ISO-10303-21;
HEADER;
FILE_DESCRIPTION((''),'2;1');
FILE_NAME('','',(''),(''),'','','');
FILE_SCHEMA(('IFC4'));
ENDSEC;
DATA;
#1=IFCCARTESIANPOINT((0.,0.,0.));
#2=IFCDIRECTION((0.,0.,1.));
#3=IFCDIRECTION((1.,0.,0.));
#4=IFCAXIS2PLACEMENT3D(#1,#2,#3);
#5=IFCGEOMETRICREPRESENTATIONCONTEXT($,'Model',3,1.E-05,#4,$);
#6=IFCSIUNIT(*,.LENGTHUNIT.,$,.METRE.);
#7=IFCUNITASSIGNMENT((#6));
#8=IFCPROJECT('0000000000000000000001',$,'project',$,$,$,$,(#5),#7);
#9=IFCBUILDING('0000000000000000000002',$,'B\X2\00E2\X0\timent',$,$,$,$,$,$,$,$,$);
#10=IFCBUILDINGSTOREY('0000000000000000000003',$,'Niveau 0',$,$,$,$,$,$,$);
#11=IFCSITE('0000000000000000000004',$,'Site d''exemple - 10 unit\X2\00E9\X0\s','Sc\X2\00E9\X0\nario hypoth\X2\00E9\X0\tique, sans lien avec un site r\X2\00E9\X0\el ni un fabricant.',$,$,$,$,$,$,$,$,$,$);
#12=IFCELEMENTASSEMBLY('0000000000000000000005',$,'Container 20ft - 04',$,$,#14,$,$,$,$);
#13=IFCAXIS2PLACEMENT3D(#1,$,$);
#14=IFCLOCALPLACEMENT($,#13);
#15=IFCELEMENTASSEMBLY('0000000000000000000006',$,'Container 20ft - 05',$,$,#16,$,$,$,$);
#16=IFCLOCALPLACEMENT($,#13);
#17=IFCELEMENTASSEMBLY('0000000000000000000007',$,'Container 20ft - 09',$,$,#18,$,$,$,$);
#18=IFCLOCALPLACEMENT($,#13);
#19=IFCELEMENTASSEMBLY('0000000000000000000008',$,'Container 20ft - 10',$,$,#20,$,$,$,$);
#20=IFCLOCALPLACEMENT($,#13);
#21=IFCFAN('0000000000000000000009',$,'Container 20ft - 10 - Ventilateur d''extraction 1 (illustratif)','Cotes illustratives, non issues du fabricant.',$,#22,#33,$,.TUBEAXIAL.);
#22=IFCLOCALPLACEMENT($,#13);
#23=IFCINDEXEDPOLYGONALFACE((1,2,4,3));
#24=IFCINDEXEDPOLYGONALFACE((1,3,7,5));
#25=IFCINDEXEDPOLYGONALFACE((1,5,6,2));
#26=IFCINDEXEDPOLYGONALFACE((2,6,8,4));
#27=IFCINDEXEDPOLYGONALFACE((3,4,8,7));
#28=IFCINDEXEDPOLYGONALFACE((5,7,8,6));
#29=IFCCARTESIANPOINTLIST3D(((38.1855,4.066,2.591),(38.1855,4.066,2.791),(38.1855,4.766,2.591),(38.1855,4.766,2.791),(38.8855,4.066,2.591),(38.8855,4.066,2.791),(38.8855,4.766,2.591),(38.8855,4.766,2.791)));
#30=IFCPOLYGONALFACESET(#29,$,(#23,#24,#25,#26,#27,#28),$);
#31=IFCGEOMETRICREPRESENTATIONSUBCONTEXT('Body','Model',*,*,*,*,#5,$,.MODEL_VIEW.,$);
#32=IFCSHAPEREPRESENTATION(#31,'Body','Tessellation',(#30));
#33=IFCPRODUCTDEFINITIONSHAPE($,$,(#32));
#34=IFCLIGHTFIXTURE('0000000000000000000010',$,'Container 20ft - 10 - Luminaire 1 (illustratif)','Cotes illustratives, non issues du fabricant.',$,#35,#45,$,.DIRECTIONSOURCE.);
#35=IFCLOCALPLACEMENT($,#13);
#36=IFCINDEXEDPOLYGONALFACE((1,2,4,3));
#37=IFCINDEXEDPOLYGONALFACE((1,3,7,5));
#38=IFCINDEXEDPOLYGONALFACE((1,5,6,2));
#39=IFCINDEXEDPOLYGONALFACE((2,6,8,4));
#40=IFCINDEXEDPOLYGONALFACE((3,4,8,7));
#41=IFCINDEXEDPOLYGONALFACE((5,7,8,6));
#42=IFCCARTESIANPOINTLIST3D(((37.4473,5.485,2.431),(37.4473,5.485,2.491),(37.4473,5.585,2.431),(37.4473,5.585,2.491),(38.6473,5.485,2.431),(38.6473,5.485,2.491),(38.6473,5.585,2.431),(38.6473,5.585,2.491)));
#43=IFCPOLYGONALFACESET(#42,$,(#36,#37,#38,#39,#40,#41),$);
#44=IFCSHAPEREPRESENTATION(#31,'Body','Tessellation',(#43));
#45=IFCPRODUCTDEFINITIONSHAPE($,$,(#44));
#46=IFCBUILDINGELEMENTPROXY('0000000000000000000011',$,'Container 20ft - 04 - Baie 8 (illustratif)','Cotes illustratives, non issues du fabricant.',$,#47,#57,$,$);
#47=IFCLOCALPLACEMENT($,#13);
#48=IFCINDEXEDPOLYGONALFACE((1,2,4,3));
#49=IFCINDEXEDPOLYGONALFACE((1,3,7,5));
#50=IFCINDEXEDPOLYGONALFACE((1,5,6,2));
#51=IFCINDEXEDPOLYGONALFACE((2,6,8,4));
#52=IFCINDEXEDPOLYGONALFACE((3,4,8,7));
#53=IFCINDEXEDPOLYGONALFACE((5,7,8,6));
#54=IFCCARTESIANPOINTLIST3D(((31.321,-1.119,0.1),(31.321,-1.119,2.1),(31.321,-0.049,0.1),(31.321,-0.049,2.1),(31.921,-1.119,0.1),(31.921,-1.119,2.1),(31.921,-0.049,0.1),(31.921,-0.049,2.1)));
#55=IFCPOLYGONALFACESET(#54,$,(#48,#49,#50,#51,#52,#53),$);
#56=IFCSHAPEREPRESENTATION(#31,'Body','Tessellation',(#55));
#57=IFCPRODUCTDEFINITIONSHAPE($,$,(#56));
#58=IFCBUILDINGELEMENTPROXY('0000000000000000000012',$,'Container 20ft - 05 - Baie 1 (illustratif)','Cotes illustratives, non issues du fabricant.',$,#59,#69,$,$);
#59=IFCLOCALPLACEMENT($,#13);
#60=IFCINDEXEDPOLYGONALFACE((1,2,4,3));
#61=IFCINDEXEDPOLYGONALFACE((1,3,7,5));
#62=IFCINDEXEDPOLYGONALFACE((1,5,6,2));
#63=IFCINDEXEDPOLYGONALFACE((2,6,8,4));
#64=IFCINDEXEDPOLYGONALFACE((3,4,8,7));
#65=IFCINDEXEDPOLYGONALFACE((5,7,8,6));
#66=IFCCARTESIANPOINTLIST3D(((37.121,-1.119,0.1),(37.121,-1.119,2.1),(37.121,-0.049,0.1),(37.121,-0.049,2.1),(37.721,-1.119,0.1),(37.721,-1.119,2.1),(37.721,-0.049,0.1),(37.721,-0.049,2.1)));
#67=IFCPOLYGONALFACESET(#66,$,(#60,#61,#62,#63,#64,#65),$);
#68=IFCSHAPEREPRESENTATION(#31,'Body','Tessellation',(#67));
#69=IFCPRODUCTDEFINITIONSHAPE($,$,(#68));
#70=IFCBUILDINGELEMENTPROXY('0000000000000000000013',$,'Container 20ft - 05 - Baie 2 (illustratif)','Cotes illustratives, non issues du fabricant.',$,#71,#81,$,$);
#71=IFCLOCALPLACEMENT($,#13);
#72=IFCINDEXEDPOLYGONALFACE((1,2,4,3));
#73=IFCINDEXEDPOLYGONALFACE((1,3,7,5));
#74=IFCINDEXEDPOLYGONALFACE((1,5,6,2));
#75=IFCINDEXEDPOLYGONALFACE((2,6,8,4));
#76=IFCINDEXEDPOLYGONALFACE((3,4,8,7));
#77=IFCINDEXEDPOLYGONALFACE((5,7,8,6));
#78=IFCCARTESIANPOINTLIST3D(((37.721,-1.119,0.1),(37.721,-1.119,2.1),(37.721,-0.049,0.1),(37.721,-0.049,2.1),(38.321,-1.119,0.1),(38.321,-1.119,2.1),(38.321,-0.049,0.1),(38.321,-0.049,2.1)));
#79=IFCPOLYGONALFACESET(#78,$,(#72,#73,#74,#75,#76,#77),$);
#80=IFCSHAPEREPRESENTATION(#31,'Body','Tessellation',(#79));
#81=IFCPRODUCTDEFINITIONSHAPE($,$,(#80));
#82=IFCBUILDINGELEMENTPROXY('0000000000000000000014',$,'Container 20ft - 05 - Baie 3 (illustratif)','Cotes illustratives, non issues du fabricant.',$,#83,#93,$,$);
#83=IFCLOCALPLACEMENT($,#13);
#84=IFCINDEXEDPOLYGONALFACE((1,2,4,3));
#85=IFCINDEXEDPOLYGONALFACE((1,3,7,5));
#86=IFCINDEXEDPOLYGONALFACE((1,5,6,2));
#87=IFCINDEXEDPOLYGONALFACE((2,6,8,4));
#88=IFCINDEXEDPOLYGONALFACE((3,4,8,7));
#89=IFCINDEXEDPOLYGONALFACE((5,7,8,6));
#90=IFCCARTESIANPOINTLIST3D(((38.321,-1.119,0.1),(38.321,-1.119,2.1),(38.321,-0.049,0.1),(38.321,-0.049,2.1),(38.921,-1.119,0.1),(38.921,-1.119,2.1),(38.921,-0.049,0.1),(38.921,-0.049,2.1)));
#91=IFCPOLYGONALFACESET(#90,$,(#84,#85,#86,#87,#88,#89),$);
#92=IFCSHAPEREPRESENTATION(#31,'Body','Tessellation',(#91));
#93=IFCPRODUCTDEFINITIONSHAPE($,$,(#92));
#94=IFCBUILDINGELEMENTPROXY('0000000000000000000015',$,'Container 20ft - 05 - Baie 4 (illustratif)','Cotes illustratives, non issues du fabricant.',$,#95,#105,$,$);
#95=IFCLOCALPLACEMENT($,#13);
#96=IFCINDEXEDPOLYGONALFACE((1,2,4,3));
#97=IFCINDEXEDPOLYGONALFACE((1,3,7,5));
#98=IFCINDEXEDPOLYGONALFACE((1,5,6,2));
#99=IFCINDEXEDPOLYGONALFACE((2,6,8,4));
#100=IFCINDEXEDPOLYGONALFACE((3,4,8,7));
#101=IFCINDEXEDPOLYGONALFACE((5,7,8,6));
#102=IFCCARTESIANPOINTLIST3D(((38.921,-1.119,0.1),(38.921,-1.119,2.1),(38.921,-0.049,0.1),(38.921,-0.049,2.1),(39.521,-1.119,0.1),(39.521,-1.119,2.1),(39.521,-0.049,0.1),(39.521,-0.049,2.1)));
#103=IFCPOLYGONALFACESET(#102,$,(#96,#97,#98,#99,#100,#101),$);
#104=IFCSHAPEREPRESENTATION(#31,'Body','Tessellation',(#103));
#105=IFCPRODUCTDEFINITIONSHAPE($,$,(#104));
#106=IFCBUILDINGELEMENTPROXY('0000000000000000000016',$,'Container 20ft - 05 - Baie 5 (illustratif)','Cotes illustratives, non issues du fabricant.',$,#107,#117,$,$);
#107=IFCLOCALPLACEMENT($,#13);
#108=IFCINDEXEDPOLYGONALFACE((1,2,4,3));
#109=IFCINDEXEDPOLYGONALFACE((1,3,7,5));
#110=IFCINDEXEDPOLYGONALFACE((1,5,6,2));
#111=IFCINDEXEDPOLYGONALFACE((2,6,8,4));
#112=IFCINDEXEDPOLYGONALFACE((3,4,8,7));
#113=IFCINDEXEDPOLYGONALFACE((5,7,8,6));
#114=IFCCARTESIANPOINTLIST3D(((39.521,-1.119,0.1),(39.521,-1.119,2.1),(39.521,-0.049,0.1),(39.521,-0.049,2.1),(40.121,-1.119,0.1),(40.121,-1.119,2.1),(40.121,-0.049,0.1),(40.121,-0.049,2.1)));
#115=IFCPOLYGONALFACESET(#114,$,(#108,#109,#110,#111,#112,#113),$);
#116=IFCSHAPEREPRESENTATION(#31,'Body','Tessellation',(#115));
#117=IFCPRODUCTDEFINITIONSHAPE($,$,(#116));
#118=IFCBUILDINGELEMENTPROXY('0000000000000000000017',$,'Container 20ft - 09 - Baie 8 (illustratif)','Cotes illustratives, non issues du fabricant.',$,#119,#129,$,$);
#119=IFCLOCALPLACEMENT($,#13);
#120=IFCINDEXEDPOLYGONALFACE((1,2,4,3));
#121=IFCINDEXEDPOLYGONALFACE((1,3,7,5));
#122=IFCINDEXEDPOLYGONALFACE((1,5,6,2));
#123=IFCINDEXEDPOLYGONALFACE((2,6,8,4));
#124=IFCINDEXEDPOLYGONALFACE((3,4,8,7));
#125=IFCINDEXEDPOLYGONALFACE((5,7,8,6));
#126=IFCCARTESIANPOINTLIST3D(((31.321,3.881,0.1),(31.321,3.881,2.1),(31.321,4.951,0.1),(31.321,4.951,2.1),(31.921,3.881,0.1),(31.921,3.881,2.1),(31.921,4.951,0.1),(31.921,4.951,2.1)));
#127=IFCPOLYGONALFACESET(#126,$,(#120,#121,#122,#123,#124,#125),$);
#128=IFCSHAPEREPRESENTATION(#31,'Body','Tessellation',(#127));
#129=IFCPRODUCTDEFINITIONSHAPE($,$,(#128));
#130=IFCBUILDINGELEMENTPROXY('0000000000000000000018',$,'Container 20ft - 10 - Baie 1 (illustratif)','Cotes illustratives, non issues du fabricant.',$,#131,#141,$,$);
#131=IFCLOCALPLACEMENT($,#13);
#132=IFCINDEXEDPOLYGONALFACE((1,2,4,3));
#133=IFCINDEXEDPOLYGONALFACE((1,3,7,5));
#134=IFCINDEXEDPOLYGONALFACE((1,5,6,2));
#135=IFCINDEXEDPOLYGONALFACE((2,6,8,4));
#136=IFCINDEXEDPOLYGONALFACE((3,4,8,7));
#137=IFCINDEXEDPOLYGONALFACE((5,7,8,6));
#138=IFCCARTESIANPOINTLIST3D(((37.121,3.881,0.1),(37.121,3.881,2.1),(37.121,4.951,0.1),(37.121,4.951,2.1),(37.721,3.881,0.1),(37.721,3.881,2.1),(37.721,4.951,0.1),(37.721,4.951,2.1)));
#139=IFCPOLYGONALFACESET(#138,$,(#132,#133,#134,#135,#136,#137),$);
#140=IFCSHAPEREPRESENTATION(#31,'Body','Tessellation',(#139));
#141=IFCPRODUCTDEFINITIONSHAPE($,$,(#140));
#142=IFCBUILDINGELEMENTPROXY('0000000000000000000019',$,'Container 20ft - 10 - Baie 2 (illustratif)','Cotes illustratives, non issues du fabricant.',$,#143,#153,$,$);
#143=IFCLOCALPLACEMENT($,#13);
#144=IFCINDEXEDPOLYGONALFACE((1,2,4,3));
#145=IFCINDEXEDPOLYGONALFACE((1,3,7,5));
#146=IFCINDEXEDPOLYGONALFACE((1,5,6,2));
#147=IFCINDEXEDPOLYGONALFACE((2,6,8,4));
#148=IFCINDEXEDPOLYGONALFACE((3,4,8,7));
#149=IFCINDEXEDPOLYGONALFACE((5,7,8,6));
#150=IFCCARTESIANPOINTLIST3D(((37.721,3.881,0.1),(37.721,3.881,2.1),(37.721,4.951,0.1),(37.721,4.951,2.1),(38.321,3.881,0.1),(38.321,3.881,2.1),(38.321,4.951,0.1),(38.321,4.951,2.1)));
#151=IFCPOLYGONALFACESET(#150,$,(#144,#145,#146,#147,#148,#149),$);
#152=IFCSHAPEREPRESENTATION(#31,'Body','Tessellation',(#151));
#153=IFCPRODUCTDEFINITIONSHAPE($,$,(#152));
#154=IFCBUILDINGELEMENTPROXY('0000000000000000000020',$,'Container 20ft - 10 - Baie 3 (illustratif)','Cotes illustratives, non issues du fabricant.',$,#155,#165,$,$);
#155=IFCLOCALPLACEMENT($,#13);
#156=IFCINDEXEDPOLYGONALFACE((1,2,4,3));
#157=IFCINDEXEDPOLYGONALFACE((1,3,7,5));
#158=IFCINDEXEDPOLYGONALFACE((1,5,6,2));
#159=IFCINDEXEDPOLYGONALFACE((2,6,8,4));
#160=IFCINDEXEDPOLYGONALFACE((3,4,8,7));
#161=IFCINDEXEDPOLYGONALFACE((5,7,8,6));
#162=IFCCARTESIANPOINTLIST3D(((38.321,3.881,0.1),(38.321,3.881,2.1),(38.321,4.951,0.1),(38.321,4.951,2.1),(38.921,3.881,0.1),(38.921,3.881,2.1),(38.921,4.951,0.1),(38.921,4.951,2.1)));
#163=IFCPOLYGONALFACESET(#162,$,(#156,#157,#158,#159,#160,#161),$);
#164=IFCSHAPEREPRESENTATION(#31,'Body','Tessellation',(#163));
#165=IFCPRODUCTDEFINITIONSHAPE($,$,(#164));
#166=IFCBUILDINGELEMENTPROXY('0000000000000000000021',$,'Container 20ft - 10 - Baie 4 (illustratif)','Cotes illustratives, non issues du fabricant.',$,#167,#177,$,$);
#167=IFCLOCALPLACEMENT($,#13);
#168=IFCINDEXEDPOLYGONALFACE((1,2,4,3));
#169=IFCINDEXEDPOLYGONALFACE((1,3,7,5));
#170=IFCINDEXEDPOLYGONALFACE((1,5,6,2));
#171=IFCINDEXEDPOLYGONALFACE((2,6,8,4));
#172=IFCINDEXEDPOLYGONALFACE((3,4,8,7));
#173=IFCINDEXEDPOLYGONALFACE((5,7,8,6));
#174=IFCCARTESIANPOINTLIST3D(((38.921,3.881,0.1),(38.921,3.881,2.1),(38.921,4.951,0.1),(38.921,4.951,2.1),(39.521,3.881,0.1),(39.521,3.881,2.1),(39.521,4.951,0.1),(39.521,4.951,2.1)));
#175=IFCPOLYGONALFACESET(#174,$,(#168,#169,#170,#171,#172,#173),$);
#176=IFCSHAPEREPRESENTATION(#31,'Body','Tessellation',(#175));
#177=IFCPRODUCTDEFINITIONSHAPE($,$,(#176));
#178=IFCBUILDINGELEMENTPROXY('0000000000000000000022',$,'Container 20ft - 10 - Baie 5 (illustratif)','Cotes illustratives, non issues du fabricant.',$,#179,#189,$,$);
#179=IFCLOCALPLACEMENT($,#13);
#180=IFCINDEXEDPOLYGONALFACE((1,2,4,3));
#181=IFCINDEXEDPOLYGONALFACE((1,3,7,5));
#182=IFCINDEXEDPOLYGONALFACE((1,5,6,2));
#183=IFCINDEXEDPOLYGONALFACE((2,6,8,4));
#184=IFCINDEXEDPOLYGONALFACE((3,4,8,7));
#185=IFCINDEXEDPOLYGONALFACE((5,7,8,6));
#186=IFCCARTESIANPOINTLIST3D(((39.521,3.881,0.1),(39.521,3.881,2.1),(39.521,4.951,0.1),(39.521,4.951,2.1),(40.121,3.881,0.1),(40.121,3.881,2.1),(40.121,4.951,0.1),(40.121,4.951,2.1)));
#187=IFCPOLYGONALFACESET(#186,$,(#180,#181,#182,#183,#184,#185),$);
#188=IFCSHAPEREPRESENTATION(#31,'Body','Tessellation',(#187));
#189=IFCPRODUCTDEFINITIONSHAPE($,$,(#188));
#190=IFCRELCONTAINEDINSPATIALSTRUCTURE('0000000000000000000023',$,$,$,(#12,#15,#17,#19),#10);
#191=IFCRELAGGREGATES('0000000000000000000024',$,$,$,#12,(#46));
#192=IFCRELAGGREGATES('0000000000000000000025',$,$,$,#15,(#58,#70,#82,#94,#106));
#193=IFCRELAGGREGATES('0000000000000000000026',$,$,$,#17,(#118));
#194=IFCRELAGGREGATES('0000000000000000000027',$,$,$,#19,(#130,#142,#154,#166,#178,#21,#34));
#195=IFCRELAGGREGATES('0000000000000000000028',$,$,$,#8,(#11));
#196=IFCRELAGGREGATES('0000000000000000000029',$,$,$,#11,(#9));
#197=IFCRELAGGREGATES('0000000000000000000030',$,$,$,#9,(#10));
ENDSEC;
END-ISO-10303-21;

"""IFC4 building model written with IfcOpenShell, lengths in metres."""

from ifc_helpers import new_model, si_unit, frame, origin_with_axes, place, context, subcontext, project, spatial, rectangle, extrude, element, aggregate, save


model = new_model("IFC4")

# Units and contexts
model_context = context("Model", 3, precision=1e-05, world=origin_with_axes())
body_context = subcontext(model_context, "Body", "Model", "MODEL_VIEW")
ifc_project = project(units=[si_unit("LENGTHUNIT", "METRE")], contexts=[model_context])

# Site, building, storey
site = spatial("IfcSite", under=ifc_project, Name="Site d'exemple - 10 unités", Description="Scénario hypothétique, sans lien avec un site réel ni un fabricant.")
building = spatial("IfcBuilding", under=site, Name="Bâtiment")
storey = spatial("IfcBuildingStorey", under=building, Name="Niveau 0")

# Element assembly
assembly_1 = element("IfcElementAssembly", 1, inside=storey, Name="Container 20ft - 04")

# Element assembly
assembly_2 = element("IfcElementAssembly", 2, inside=storey, Name="Container 20ft - 05")

# Element assembly
assembly_3 = element("IfcElementAssembly", 3, inside=storey, Name="Container 20ft - 09")

# Element assembly
assembly_4 = element("IfcElementAssembly", 4, inside=storey, Name="Container 20ft - 10")

# Fan
fan_1_placement = place(None, frame((38.5355, 4.416, 2.591), z_axis=(0.0, 0.0, 1.0), x_axis=(1.0, 0.0, 0.0)))
fan_1 = element("IfcFan", 5, at=fan_1_placement, Name="Container 20ft - 10 - Ventilateur d'extraction 1 (illustratif)", Description="Cotes illustratives, non issues du fabricant.", PredefinedType="TUBEAXIAL", context=body_context, shape_type="SweptSolid", body=[
    extrude(rectangle(XDim=0.7, YDim=0.7), origin_with_axes(), (0.0, 0.0, 1.0), 0.2),
])

# Light fixture
light_fixture_1_placement = place(None, frame((38.0473, 5.535, 2.431), z_axis=(0.0, 0.0, 1.0), x_axis=(1.0, 0.0, 0.0)))
light_fixture_1 = element("IfcLightFixture", 6, at=light_fixture_1_placement, Name="Container 20ft - 10 - Luminaire 1 (illustratif)", Description="Cotes illustratives, non issues du fabricant.", PredefinedType="DIRECTIONSOURCE", context=body_context, shape_type="SweptSolid", body=[
    extrude(rectangle(XDim=1.2, YDim=0.1), origin_with_axes(), (0.0, 0.0, 1.0), 0.06),
])

# Building element proxies
proxy_1_placement = place(None, frame((31.621, -0.584, 0.1), z_axis=(0.0, 0.0, 1.0), x_axis=(1.0, 0.0, 0.0)))
proxy_1 = element("IfcBuildingElementProxy", 7, at=proxy_1_placement, Name="Container 20ft - 04 - Baie 8 (illustratif)", Description="Cotes illustratives, non issues du fabricant.", context=body_context, shape_type="SweptSolid", body=[
    extrude(rectangle(XDim=0.6, YDim=1.07), origin_with_axes(), (0.0, 0.0, 1.0), 2.0),
])
aggregate(assembly_1, [proxy_1])
proxy_2_placement = place(None, frame((37.421, -0.584, 0.1), z_axis=(0.0, 0.0, 1.0), x_axis=(1.0, 0.0, 0.0)))
proxy_2 = element("IfcBuildingElementProxy", 8, at=proxy_2_placement, Name="Container 20ft - 05 - Baie 1 (illustratif)", Description="Cotes illustratives, non issues du fabricant.", context=body_context, shape_type="SweptSolid", body=[
    extrude(rectangle(XDim=0.6, YDim=1.07), origin_with_axes(), (0.0, 0.0, 1.0), 2.0),
])
proxy_3_placement = place(None, frame((38.021, -0.584, 0.1), z_axis=(0.0, 0.0, 1.0), x_axis=(1.0, 0.0, 0.0)))
proxy_3 = element("IfcBuildingElementProxy", 9, at=proxy_3_placement, Name="Container 20ft - 05 - Baie 2 (illustratif)", Description="Cotes illustratives, non issues du fabricant.", context=body_context, shape_type="SweptSolid", body=[
    extrude(rectangle(XDim=0.6, YDim=1.07), origin_with_axes(), (0.0, 0.0, 1.0), 2.0),
])
proxy_4_placement = place(None, frame((38.621, -0.584, 0.1), z_axis=(0.0, 0.0, 1.0), x_axis=(1.0, 0.0, 0.0)))
proxy_4 = element("IfcBuildingElementProxy", 10, at=proxy_4_placement, Name="Container 20ft - 05 - Baie 3 (illustratif)", Description="Cotes illustratives, non issues du fabricant.", context=body_context, shape_type="SweptSolid", body=[
    extrude(rectangle(XDim=0.6, YDim=1.07), origin_with_axes(), (0.0, 0.0, 1.0), 2.0),
])
proxy_5_placement = place(None, frame((39.221, -0.584, 0.1), z_axis=(0.0, 0.0, 1.0), x_axis=(1.0, 0.0, 0.0)))
proxy_5 = element("IfcBuildingElementProxy", 11, at=proxy_5_placement, Name="Container 20ft - 05 - Baie 4 (illustratif)", Description="Cotes illustratives, non issues du fabricant.", context=body_context, shape_type="SweptSolid", body=[
    extrude(rectangle(XDim=0.6, YDim=1.07), origin_with_axes(), (0.0, 0.0, 1.0), 2.0),
])
proxy_6_placement = place(None, frame((39.821, -0.584, 0.1), z_axis=(0.0, 0.0, 1.0), x_axis=(1.0, 0.0, 0.0)))
proxy_6 = element("IfcBuildingElementProxy", 12, at=proxy_6_placement, Name="Container 20ft - 05 - Baie 5 (illustratif)", Description="Cotes illustratives, non issues du fabricant.", context=body_context, shape_type="SweptSolid", body=[
    extrude(rectangle(XDim=0.6, YDim=1.07), origin_with_axes(), (0.0, 0.0, 1.0), 2.0),
])
aggregate(assembly_2, [proxy_2, proxy_3, proxy_4, proxy_5, proxy_6])
proxy_7_placement = place(None, frame((31.621, 4.416, 0.1), z_axis=(0.0, 0.0, 1.0), x_axis=(1.0, 0.0, 0.0)))
proxy_7 = element("IfcBuildingElementProxy", 13, at=proxy_7_placement, Name="Container 20ft - 09 - Baie 8 (illustratif)", Description="Cotes illustratives, non issues du fabricant.", context=body_context, shape_type="SweptSolid", body=[
    extrude(rectangle(XDim=0.6, YDim=1.07), origin_with_axes(), (0.0, 0.0, 1.0), 2.0),
])
aggregate(assembly_3, [proxy_7])
proxy_8_placement = place(None, frame((37.421, 4.416, 0.1), z_axis=(0.0, 0.0, 1.0), x_axis=(1.0, 0.0, 0.0)))
proxy_8 = element("IfcBuildingElementProxy", 14, at=proxy_8_placement, Name="Container 20ft - 10 - Baie 1 (illustratif)", Description="Cotes illustratives, non issues du fabricant.", context=body_context, shape_type="SweptSolid", body=[
    extrude(rectangle(XDim=0.6, YDim=1.07), origin_with_axes(), (0.0, 0.0, 1.0), 2.0),
])
proxy_9_placement = place(None, frame((38.021, 4.416, 0.1), z_axis=(0.0, 0.0, 1.0), x_axis=(1.0, 0.0, 0.0)))
proxy_9 = element("IfcBuildingElementProxy", 15, at=proxy_9_placement, Name="Container 20ft - 10 - Baie 2 (illustratif)", Description="Cotes illustratives, non issues du fabricant.", context=body_context, shape_type="SweptSolid", body=[
    extrude(rectangle(XDim=0.6, YDim=1.07), origin_with_axes(), (0.0, 0.0, 1.0), 2.0),
])
proxy_10_placement = place(None, frame((38.621, 4.416, 0.1), z_axis=(0.0, 0.0, 1.0), x_axis=(1.0, 0.0, 0.0)))
proxy_10 = element("IfcBuildingElementProxy", 16, at=proxy_10_placement, Name="Container 20ft - 10 - Baie 3 (illustratif)", Description="Cotes illustratives, non issues du fabricant.", context=body_context, shape_type="SweptSolid", body=[
    extrude(rectangle(XDim=0.6, YDim=1.07), origin_with_axes(), (0.0, 0.0, 1.0), 2.0),
])
proxy_11_placement = place(None, frame((39.221, 4.416, 0.1), z_axis=(0.0, 0.0, 1.0), x_axis=(1.0, 0.0, 0.0)))
proxy_11 = element("IfcBuildingElementProxy", 17, at=proxy_11_placement, Name="Container 20ft - 10 - Baie 4 (illustratif)", Description="Cotes illustratives, non issues du fabricant.", context=body_context, shape_type="SweptSolid", body=[
    extrude(rectangle(XDim=0.6, YDim=1.07), origin_with_axes(), (0.0, 0.0, 1.0), 2.0),
])
proxy_12_placement = place(None, frame((39.821, 4.416, 0.1), z_axis=(0.0, 0.0, 1.0), x_axis=(1.0, 0.0, 0.0)))
proxy_12 = element("IfcBuildingElementProxy", 18, at=proxy_12_placement, Name="Container 20ft - 10 - Baie 5 (illustratif)", Description="Cotes illustratives, non issues du fabricant.", context=body_context, shape_type="SweptSolid", body=[
    extrude(rectangle(XDim=0.6, YDim=1.07), origin_with_axes(), (0.0, 0.0, 1.0), 2.0),
])
aggregate(assembly_4, [proxy_8, proxy_9, proxy_10, proxy_11, proxy_12, fan_1, light_fixture_1])

save(model, "model.ifc")
